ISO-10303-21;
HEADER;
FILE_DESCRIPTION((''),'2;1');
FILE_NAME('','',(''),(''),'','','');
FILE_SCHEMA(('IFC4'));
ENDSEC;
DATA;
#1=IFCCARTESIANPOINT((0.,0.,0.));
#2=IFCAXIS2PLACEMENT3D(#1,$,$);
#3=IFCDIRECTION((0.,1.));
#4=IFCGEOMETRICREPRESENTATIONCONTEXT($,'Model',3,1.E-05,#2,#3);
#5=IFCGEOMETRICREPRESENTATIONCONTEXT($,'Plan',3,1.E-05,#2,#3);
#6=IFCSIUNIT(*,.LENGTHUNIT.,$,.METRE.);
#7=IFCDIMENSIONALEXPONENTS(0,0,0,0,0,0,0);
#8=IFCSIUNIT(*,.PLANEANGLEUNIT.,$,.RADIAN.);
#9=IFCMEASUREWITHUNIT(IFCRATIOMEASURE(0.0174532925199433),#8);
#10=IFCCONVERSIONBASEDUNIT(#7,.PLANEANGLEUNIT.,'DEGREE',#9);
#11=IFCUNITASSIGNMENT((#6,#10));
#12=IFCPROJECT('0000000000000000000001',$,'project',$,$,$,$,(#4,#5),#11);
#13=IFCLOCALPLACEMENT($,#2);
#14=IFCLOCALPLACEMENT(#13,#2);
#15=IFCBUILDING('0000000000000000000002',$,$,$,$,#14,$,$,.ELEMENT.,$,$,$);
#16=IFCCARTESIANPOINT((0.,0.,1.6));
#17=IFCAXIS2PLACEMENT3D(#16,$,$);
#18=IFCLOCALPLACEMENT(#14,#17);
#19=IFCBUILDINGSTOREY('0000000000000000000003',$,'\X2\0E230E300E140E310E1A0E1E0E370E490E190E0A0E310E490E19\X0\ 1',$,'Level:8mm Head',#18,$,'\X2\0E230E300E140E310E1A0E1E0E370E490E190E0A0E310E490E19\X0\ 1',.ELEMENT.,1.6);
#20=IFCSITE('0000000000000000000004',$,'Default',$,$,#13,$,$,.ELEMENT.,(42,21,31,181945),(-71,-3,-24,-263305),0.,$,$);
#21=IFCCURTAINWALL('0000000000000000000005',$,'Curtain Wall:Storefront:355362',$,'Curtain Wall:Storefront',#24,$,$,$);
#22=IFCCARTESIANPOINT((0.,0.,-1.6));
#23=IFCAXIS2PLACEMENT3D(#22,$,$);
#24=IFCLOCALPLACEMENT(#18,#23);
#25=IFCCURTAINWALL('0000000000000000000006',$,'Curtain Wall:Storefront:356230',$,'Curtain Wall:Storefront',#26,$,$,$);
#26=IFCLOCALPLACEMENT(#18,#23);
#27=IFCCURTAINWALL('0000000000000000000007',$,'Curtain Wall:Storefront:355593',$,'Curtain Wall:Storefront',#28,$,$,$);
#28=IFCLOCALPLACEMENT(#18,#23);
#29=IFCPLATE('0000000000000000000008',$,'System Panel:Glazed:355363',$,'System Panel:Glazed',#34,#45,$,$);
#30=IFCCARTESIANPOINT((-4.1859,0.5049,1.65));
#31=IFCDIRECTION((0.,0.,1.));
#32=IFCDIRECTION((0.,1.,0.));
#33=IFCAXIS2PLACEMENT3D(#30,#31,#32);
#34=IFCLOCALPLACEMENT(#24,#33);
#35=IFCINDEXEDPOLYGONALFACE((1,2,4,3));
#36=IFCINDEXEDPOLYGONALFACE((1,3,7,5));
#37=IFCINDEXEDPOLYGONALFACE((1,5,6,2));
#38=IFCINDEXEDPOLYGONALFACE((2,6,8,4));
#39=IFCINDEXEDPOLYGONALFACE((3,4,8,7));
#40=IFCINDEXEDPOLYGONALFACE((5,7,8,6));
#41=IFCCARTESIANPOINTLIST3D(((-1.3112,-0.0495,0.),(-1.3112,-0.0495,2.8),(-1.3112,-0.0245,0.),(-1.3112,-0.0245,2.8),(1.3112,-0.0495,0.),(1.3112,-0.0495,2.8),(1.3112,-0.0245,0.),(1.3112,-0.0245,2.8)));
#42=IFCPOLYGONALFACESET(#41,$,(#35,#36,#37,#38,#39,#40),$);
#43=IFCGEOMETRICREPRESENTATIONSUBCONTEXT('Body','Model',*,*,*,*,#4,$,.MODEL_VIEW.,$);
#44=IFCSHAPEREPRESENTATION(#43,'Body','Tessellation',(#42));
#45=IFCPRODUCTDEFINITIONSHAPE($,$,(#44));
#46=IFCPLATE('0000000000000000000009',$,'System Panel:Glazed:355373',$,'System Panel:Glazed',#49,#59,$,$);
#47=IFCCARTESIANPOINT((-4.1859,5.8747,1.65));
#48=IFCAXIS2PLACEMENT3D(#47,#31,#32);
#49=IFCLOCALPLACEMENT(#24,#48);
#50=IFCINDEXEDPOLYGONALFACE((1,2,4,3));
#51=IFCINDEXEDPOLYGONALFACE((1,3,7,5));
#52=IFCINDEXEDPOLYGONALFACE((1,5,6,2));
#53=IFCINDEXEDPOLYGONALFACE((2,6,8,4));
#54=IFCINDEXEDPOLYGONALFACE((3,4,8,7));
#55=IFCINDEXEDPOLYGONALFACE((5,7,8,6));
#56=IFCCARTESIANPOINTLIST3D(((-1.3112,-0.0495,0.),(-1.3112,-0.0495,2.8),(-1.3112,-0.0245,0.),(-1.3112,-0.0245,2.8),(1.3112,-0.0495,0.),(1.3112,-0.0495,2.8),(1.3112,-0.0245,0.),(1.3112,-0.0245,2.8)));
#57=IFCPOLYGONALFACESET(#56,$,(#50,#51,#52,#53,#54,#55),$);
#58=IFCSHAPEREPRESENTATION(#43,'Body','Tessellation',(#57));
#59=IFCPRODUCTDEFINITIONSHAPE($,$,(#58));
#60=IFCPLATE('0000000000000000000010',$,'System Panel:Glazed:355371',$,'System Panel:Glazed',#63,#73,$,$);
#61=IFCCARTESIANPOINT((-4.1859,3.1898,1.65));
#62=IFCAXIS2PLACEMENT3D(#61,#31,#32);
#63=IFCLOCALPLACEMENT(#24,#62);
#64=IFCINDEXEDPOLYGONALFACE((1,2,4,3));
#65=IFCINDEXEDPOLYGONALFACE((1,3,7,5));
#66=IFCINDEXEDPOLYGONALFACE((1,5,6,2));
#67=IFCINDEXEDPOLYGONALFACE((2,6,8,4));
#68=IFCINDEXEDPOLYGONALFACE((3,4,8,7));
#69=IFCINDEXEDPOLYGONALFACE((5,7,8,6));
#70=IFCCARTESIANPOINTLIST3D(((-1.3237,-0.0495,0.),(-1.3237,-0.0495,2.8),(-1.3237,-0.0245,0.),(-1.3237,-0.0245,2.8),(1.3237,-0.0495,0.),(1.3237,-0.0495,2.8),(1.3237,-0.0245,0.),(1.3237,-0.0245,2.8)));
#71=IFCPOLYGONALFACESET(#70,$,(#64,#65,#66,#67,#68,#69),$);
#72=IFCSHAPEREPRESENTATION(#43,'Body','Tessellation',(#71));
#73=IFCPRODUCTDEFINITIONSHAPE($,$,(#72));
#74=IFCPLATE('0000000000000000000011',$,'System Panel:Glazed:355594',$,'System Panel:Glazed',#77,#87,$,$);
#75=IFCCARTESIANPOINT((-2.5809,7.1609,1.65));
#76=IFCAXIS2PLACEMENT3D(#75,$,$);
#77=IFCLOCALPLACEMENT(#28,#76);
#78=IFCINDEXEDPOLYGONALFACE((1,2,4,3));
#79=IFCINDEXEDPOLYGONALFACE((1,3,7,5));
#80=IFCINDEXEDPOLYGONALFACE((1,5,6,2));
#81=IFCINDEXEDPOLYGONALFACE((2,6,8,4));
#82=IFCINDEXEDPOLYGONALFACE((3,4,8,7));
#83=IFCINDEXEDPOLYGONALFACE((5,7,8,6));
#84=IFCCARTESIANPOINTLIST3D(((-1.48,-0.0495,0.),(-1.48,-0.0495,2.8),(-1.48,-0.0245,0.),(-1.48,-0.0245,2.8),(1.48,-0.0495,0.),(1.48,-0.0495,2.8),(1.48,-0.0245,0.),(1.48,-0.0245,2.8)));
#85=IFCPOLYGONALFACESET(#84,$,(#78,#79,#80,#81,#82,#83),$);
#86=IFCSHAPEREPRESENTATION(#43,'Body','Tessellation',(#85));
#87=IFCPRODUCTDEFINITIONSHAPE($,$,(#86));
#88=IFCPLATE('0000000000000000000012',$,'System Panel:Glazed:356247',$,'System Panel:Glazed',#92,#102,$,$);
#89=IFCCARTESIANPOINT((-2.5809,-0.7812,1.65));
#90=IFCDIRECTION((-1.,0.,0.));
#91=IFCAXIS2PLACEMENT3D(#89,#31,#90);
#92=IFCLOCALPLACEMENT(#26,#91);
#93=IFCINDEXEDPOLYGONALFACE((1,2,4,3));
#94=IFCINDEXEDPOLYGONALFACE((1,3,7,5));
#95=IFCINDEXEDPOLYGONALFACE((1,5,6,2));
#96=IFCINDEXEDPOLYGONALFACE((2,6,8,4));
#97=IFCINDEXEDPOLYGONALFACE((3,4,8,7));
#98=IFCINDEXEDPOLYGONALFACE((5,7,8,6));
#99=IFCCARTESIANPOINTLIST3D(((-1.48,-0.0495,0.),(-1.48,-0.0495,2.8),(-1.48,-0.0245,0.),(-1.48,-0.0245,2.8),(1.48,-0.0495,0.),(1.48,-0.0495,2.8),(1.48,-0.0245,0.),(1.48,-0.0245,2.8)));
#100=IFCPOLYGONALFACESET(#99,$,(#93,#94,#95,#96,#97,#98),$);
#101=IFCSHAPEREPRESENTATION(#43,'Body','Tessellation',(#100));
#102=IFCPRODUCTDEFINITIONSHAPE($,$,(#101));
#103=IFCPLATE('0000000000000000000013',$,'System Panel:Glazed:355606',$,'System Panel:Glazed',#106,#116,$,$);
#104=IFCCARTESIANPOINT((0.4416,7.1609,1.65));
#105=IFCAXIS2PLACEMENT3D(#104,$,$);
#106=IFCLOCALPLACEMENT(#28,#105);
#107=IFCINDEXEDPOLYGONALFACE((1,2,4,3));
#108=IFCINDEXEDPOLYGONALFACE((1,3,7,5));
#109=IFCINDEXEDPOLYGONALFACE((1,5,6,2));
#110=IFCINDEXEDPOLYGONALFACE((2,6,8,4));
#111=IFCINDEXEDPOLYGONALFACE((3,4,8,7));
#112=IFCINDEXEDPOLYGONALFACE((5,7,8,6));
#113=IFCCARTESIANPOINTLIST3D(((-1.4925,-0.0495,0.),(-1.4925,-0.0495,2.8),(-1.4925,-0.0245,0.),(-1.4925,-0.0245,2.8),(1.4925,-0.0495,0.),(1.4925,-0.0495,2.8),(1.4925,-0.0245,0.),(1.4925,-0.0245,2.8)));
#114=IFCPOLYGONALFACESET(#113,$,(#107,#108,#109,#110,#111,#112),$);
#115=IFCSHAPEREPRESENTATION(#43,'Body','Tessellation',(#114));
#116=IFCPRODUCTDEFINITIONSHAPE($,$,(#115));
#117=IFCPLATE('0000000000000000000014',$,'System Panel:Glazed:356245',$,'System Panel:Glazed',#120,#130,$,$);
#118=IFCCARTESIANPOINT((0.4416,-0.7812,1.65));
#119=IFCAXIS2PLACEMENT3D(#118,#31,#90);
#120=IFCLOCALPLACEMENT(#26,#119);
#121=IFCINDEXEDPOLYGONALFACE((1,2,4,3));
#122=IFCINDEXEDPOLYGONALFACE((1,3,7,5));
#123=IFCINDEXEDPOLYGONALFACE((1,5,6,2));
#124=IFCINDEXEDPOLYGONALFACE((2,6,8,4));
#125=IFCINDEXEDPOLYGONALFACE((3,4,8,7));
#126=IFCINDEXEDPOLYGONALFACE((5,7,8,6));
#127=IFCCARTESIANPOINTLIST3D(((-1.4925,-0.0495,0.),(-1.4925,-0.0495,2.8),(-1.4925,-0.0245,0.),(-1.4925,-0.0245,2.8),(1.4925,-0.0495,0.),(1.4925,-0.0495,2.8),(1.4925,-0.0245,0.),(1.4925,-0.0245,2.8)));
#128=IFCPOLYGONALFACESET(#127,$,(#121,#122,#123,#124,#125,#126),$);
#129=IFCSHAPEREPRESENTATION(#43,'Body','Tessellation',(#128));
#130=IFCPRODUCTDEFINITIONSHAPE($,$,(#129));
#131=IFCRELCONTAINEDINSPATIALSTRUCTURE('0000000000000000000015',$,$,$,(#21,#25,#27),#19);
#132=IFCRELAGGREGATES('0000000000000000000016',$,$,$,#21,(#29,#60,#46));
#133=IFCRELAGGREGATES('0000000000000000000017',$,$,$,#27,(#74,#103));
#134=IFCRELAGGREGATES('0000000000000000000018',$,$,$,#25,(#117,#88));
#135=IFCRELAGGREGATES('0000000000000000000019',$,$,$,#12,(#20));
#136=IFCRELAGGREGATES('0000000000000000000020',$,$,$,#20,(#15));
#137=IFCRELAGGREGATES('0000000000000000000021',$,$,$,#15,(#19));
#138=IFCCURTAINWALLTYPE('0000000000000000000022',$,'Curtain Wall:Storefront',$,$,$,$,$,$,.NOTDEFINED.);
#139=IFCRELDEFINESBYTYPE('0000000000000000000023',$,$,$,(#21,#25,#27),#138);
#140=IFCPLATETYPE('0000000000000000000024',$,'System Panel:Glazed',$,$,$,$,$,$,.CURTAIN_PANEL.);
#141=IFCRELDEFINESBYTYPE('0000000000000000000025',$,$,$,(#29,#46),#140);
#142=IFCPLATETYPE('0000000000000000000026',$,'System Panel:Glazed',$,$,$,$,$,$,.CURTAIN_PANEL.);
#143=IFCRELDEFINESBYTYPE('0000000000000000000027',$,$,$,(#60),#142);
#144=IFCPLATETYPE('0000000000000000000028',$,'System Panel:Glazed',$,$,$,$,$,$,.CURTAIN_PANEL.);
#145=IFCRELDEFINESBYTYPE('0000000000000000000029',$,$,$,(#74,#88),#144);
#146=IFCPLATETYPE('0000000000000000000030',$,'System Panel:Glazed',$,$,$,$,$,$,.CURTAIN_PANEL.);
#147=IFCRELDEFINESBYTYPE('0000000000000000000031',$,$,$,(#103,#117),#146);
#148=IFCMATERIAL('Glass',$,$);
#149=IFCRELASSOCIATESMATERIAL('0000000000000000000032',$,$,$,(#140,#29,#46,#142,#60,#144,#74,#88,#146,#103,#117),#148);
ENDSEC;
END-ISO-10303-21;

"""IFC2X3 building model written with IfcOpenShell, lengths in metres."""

from ifc_helpers import new_model, entity, si_unit, converted_unit, direction, frame, frame_2d, origin, origin_2d_with_axis, place, context, subcontext, project, spatial, rectangle, extrude, source, transform, mapped, material, type_object, type_shapes, element, aggregate, save


model = new_model("IFC2X3")

# Units and contexts
model_context = context("Model", 3, precision=1e-05, world=origin(), true_north=direction((0.0, 1.0)))
plan_context = context("Plan", 3, precision=1e-05, world=origin(), true_north=direction((0.0, 1.0)))
body_context = subcontext(model_context, "Body", "Model", "MODEL_VIEW")
ifc_project = project(units=[si_unit("LENGTHUNIT", "METRE"), converted_unit("PLANEANGLEUNIT", "DEGREE", entity("IfcRatioMeasure", 0.0174532925199433), si_unit("PLANEANGLEUNIT", "RADIAN"), dimensions=[0, 0, 0, 0, 0, 0, 0])], contexts=[model_context, plan_context])

# Site, building, storey
site_placement = place(None, origin())
site = spatial("IfcSite", under=ifc_project, at=site_placement, Name="Default", CompositionType="ELEMENT", RefLatitude=(42, 21, 31, 181945), RefLongitude=(-71, -3, -24, -263305), RefElevation=0.0)
building_placement = place(site_placement, origin())
building = spatial("IfcBuilding", under=site, at=building_placement, CompositionType="ELEMENT")
storey_placement = place(building_placement, frame((0.0, 0.0, 1.6)))
storey = spatial("IfcBuildingStorey", under=building, at=storey_placement, Name="ระดับพื้นชั้น 1", ObjectType="Level:8mm Head", LongName="ระดับพื้นชั้น 1", CompositionType="ELEMENT", Elevation=1.6)

# Curtain wall
curtain_wall_type = type_object("IfcCurtainWallType", Name="Curtain Wall:Storefront", PredefinedType="NOTDEFINED")
curtain_wall_1_placement = place(storey_placement, frame((0.0, 0.0, -1.6)))
curtain_wall_1 = element("IfcCurtainWall", 1, at=curtain_wall_1_placement, inside=storey, type_object=curtain_wall_type, Name="Curtain Wall:Storefront:355362", ObjectType="Curtain Wall:Storefront")

# Curtain wall
curtain_wall_2_placement = place(storey_placement, frame((0.0, 0.0, -1.6)))
curtain_wall_2 = element("IfcCurtainWall", 2, at=curtain_wall_2_placement, inside=storey, type_object=curtain_wall_type, Name="Curtain Wall:Storefront:356230", ObjectType="Curtain Wall:Storefront")

# Curtain wall
curtain_wall_3_placement = place(storey_placement, frame((0.0, 0.0, -1.6)))
curtain_wall_3 = element("IfcCurtainWall", 3, at=curtain_wall_3_placement, inside=storey, type_object=curtain_wall_type, Name="Curtain Wall:Storefront:355593", ObjectType="Curtain Wall:Storefront")

# Plates
ifc_material_1 = material(Name="Glass")
plate_type_1 = type_object("IfcPlateType", Name="System Panel:Glazed", PredefinedType="CURTAIN_PANEL", material=ifc_material_1)
shared_shape_1 = source(origin(), body_context, "Body", "SweptSolid", [
    extrude(rectangle(XDim=0.025, YDim=2.6224, at=frame_2d((0.0, 0.0), x_axis=(1.0, 0.0))), frame((0.0, -0.037, 0.0), z_axis=(0.0, 0.0, 1.0), x_axis=(0.0, 1.0, 0.0)), (0.0, 0.0, 1.0), 2.8),
])
type_shapes(plate_type_1, [shared_shape_1])
plate_1_placement = place(curtain_wall_1_placement, frame((-4.1859, 0.5049, 1.65), z_axis=(0.0, 0.0, 1.0), x_axis=(0.0, 1.0, 0.0)))
plate_1 = element("IfcPlate", 4, at=plate_1_placement, type_object=plate_type_1, material=ifc_material_1, Name="System Panel:Glazed:355363", ObjectType="System Panel:Glazed", context=body_context, shape_type="MappedRepresentation", body=[
    mapped(shared_shape_1, transform((0.0, 0.0, 0.0), scale=1.0)),
])
plate_2_placement = place(curtain_wall_1_placement, frame((-4.1859, 5.8747, 1.65), z_axis=(0.0, 0.0, 1.0), x_axis=(0.0, 1.0, 0.0)))
plate_2 = element("IfcPlate", 5, at=plate_2_placement, type_object=plate_type_1, material=ifc_material_1, Name="System Panel:Glazed:355373", ObjectType="System Panel:Glazed", context=body_context, shape_type="MappedRepresentation", body=[
    mapped(shared_shape_1, transform((0.0, 0.0, 0.0), scale=1.0)),
])
plate_type_2 = type_object("IfcPlateType", Name="System Panel:Glazed", PredefinedType="CURTAIN_PANEL", material=ifc_material_1)
shared_shape_2 = source(origin(), body_context, "Body", "SweptSolid", [
    extrude(rectangle(XDim=0.025, YDim=2.6474, at=origin_2d_with_axis()), frame((0.0, -0.037, 0.0), z_axis=(0.0, 0.0, 1.0), x_axis=(0.0, 1.0, 0.0)), (0.0, 0.0, 1.0), 2.8),
])
type_shapes(plate_type_2, [shared_shape_2])
plate_3_placement = place(curtain_wall_1_placement, frame((-4.1859, 3.1898, 1.65), z_axis=(0.0, 0.0, 1.0), x_axis=(0.0, 1.0, 0.0)))
plate_3 = element("IfcPlate", 6, at=plate_3_placement, type_object=plate_type_2, material=ifc_material_1, Name="System Panel:Glazed:355371", ObjectType="System Panel:Glazed", context=body_context, shape_type="MappedRepresentation", body=[
    mapped(shared_shape_2, transform((0.0, 0.0, 0.0), scale=1.0)),
])
aggregate(curtain_wall_1, [plate_1, plate_3, plate_2])
plate_type_3 = type_object("IfcPlateType", Name="System Panel:Glazed", PredefinedType="CURTAIN_PANEL", material=ifc_material_1)
shared_shape_3 = source(origin(), body_context, "Body", "SweptSolid", [
    extrude(rectangle(XDim=0.025, YDim=2.96, at=frame_2d((0.0, 0.0), x_axis=(1.0, 0.0))), frame((0.0, -0.037, 0.0), z_axis=(0.0, 0.0, 1.0), x_axis=(0.0, 1.0, 0.0)), (0.0, 0.0, 1.0), 2.8),
])
type_shapes(plate_type_3, [shared_shape_3])
plate_4_placement = place(curtain_wall_3_placement, frame((-2.5809, 7.1609, 1.65)))
plate_4 = element("IfcPlate", 7, at=plate_4_placement, type_object=plate_type_3, material=ifc_material_1, Name="System Panel:Glazed:355594", ObjectType="System Panel:Glazed", context=body_context, shape_type="MappedRepresentation", body=[
    mapped(shared_shape_3, transform((0.0, 0.0, 0.0), scale=1.0)),
])
plate_5_placement = place(curtain_wall_2_placement, frame((-2.5809, -0.7812, 1.65), z_axis=(0.0, 0.0, 1.0), x_axis=(-1.0, 0.0, 0.0)))
plate_5 = element("IfcPlate", 8, at=plate_5_placement, type_object=plate_type_3, material=ifc_material_1, Name="System Panel:Glazed:356247", ObjectType="System Panel:Glazed", context=body_context, shape_type="MappedRepresentation", body=[
    mapped(shared_shape_3, transform((0.0, 0.0, 0.0), scale=1.0)),
])
plate_type_4 = type_object("IfcPlateType", Name="System Panel:Glazed", PredefinedType="CURTAIN_PANEL", material=ifc_material_1)
shared_shape_4 = source(origin(), body_context, "Body", "SweptSolid", [
    extrude(rectangle(XDim=0.025, YDim=2.985, at=frame_2d((0.0, 0.0), x_axis=(1.0, 0.0))), frame((0.0, -0.037, 0.0), z_axis=(0.0, 0.0, 1.0), x_axis=(0.0, 1.0, 0.0)), (0.0, 0.0, 1.0), 2.8),
])
type_shapes(plate_type_4, [shared_shape_4])
plate_6_placement = place(curtain_wall_3_placement, frame((0.4416, 7.1609, 1.65)))
plate_6 = element("IfcPlate", 9, at=plate_6_placement, type_object=plate_type_4, material=ifc_material_1, Name="System Panel:Glazed:355606", ObjectType="System Panel:Glazed", context=body_context, shape_type="MappedRepresentation", body=[
    mapped(shared_shape_4, transform((0.0, 0.0, 0.0), scale=1.0)),
])
aggregate(curtain_wall_3, [plate_4, plate_6])
plate_7_placement = place(curtain_wall_2_placement, frame((0.4416, -0.7812, 1.65), z_axis=(0.0, 0.0, 1.0), x_axis=(-1.0, 0.0, 0.0)))
plate_7 = element("IfcPlate", 10, at=plate_7_placement, type_object=plate_type_4, material=ifc_material_1, Name="System Panel:Glazed:356245", ObjectType="System Panel:Glazed", context=body_context, shape_type="MappedRepresentation", body=[
    mapped(shared_shape_4, transform((0.0, 0.0, 0.0), scale=1.0)),
])
aggregate(curtain_wall_2, [plate_7, plate_5])

save(model, "model.ifc")
